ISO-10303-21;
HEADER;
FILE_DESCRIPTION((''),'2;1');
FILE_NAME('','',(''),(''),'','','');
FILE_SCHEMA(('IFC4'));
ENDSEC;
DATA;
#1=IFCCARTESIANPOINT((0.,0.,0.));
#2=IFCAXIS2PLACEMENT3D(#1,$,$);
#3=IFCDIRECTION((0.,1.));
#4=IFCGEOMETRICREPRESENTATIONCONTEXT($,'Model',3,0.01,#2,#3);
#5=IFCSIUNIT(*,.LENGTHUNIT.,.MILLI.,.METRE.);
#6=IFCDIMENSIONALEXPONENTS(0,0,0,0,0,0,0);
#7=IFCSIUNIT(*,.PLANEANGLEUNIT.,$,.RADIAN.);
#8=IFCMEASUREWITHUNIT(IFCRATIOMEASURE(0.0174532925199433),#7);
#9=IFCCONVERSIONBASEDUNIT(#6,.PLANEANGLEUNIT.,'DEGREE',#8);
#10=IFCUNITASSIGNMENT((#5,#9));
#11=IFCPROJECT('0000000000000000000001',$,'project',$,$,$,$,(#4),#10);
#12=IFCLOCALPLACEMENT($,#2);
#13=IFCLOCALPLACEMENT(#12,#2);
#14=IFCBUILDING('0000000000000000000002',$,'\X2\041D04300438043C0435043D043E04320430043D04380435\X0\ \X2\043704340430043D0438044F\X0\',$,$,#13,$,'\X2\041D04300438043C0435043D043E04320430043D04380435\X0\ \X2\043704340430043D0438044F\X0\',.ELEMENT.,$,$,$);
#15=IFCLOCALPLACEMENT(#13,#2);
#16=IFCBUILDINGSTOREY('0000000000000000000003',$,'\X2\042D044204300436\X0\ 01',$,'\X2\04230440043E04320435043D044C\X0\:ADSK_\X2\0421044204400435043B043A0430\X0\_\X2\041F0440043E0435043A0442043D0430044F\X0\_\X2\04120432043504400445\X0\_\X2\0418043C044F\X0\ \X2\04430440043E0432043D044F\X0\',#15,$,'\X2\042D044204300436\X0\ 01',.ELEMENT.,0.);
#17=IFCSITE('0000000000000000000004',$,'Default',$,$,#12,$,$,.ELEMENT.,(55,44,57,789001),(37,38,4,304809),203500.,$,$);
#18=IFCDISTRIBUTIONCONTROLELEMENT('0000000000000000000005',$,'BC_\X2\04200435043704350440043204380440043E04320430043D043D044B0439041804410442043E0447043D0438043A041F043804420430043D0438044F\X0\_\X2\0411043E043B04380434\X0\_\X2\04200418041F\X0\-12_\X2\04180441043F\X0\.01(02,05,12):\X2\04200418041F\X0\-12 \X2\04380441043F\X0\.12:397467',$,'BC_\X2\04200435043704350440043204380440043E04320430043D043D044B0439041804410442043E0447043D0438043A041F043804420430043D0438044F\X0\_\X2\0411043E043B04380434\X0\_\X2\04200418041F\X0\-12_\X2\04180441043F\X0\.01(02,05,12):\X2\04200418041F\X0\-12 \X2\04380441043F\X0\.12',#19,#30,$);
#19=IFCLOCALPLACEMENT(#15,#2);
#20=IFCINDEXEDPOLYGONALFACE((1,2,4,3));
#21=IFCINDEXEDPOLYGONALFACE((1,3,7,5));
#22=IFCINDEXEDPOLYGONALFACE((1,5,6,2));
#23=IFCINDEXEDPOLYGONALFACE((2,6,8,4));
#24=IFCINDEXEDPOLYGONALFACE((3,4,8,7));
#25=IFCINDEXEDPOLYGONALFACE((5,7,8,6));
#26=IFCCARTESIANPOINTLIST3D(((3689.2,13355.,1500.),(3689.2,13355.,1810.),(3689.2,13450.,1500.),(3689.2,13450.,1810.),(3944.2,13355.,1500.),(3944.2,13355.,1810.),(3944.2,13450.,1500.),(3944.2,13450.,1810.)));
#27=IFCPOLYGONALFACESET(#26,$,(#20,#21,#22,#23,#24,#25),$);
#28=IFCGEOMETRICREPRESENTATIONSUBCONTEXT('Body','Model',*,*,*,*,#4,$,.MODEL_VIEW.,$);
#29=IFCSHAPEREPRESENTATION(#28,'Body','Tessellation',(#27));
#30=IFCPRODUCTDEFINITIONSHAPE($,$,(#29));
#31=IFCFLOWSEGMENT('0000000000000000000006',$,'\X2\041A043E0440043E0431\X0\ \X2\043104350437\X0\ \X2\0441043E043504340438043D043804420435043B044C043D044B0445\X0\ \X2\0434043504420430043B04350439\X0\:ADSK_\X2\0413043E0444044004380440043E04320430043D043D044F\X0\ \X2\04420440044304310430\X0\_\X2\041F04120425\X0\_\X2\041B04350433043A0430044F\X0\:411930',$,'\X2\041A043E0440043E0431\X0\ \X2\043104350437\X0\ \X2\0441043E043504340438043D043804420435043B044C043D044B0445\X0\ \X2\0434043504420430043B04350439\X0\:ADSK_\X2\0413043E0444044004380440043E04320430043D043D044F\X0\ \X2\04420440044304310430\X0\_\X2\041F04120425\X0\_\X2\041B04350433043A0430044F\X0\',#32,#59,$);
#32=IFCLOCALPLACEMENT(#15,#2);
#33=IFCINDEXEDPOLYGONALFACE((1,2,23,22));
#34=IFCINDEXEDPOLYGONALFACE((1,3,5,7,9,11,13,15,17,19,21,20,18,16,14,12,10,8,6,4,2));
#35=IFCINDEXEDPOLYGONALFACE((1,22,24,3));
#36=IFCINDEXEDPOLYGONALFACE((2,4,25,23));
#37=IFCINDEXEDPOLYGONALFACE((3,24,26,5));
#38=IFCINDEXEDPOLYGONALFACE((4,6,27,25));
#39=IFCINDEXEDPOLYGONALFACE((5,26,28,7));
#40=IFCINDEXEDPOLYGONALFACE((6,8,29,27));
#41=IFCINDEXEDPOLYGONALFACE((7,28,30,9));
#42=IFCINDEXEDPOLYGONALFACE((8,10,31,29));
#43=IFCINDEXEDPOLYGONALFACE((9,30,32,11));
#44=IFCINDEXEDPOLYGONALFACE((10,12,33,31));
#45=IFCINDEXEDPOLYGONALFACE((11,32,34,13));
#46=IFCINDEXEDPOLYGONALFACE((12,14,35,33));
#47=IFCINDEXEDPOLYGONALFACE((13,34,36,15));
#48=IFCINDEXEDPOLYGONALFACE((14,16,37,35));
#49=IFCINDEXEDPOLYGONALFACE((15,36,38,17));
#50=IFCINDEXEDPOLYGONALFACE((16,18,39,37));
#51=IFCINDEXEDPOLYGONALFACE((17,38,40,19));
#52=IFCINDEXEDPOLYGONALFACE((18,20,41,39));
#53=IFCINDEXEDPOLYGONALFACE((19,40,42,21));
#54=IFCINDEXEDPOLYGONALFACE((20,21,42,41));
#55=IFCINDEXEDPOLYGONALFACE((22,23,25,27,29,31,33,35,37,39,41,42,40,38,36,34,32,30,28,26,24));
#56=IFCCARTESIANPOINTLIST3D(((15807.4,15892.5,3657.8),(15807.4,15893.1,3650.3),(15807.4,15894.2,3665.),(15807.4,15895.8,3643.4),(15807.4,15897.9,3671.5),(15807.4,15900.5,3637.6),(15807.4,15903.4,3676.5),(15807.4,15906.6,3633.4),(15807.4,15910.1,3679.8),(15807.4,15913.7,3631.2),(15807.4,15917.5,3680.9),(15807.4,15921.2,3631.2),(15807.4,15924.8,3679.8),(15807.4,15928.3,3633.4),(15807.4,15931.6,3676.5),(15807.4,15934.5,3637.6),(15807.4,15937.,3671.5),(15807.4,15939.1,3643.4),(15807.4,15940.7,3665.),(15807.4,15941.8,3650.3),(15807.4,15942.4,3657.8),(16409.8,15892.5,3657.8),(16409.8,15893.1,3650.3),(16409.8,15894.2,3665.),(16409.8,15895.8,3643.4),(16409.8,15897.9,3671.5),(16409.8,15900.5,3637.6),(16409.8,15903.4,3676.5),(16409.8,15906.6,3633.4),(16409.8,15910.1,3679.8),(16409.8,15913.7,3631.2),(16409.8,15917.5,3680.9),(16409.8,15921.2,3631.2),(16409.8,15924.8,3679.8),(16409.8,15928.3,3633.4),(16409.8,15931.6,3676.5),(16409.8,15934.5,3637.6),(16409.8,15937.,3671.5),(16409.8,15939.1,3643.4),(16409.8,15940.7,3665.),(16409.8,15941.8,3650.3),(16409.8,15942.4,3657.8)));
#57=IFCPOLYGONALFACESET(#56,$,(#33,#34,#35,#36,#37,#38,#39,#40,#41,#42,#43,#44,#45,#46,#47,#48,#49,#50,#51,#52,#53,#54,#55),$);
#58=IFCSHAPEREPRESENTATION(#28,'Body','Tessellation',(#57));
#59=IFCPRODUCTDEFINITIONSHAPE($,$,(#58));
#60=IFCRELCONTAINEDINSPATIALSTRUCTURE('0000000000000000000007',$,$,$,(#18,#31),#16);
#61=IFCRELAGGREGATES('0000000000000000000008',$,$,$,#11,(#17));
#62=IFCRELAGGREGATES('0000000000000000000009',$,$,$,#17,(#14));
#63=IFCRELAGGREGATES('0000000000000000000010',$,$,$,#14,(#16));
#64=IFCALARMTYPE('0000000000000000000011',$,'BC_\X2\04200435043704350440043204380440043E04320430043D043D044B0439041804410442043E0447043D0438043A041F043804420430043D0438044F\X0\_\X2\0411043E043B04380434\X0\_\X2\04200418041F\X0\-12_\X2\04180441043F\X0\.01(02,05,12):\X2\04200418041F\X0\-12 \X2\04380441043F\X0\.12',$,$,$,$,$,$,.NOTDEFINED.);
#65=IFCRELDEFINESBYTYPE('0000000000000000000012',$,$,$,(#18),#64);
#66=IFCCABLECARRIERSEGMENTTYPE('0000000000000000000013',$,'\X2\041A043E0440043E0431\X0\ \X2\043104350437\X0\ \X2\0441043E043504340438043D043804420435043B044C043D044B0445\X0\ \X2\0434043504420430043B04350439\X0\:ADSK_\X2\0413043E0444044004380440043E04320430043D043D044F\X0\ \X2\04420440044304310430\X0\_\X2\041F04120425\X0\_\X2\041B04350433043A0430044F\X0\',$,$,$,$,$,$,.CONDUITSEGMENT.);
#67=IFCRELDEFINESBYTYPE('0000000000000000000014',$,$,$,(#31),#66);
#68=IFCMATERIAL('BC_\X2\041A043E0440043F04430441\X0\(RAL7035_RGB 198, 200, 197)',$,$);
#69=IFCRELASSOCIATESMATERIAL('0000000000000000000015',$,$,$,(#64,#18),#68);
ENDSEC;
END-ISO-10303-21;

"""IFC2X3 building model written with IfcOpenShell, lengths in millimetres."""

from ifc_helpers import new_model, entity, si_unit, converted_unit, direction, frame, frame_2d, origin, origin_2d_with_axis, place, context, subcontext, project, spatial, rectangle, circle, extrude, source, transform, mapped, material, type_object, type_shapes, element, save


model = new_model("IFC2X3")

# Units and contexts
model_context = context("Model", 3, precision=0.01, world=origin(), true_north=direction((0.0, 1.0)))
body_context = subcontext(model_context, "Body", "Model", "MODEL_VIEW")
ifc_project = project(units=[si_unit("LENGTHUNIT", "METRE", prefix="MILLI"), converted_unit("PLANEANGLEUNIT", "DEGREE", entity("IfcRatioMeasure", 0.0174532925199433), si_unit("PLANEANGLEUNIT", "RADIAN"), dimensions=[0, 0, 0, 0, 0, 0, 0])], contexts=[model_context])

# Site, building, storey
site_placement = place(None, frame((0.0, 0.0, 0.0)))
site = spatial("IfcSite", under=ifc_project, at=site_placement, Name="Default", CompositionType="ELEMENT", RefLatitude=(55, 44, 57, 789001), RefLongitude=(37, 38, 4, 304809), RefElevation=203500.0)
building_placement = place(site_placement, origin())
building = spatial("IfcBuilding", under=site, at=building_placement, Name="Наименование здания", LongName="Наименование здания", CompositionType="ELEMENT")
storey_placement = place(building_placement, origin())
storey = spatial("IfcBuildingStorey", under=building, at=storey_placement, Name="Этаж 01", ObjectType="Уровень:ADSK_Стрелка_Проектная_Вверх_Имя уровня", LongName="Этаж 01", CompositionType="ELEMENT", Elevation=0.0)

# Distribution control element
ifc_material = material(Name="BC_Корпус(RAL7035_RGB 198, 200, 197)")
alarm_type = type_object("IfcAlarmType", Name="BC_РезервированныйИсточникПитания_Болид_РИП-12_Исп.01(02,05,12):РИП-12 исп.12", PredefinedType="NOTDEFINED", material=ifc_material)
shared_shape = source(origin(), body_context, "Body", "SweptSolid", [
    extrude(rectangle(XDim=255.0, YDim=310.0, at=origin_2d_with_axis()), frame((0.0, 0.0, 0.0), z_axis=(0.0, 0.0, 1.0), x_axis=(-1.0, 0.0, 0.0)), (0.0, 0.0, 1.0), 95.0),
])
type_shapes(alarm_type, [shared_shape])
distribution_control_element_placement = place(storey_placement, frame((3816.7, 13450.0, 1655.0), z_axis=(0.0, -1.0, 0.0), x_axis=(1.0, 0.0, 0.0)))
element("IfcDistributionControlElement", 1, at=distribution_control_element_placement, inside=storey, type_object=alarm_type, material=ifc_material, Name="BC_РезервированныйИсточникПитания_Болид_РИП-12_Исп.01(02,05,12):РИП-12 исп.12:397467", ObjectType="BC_РезервированныйИсточникПитания_Болид_РИП-12_Исп.01(02,05,12):РИП-12 исп.12", context=body_context, shape_type="MappedRepresentation", body=[
    mapped(shared_shape, transform((0.0, 0.0, 0.0), scale=1.0)),
])

# Flow segment
cable_carrier_segment_type = type_object("IfcCableCarrierSegmentType", Name="Короб без соединительных деталей:ADSK_Гофрировання труба_ПВХ_Легкая", PredefinedType="CONDUITSEGMENT")
flow_segment_1_placement = place(storey_placement, frame((15807.4, 15890.9, 3629.3)))
element("IfcFlowSegment", 2, at=flow_segment_1_placement, inside=storey, type_object=cable_carrier_segment_type, Name="Короб без соединительных деталей:ADSK_Гофрировання труба_ПВХ_Легкая:411930", ObjectType="Короб без соединительных деталей:ADSK_Гофрировання труба_ПВХ_Легкая", context=body_context, shape_type="SweptSolid", body=[
    extrude(circle(Radius=25.0, at=frame_2d((0.0, 0.0), x_axis=(1.0, 0.0))), frame((0.0, 26.6, 26.6), z_axis=(1.0, 0.0, -0.000002), x_axis=(0.000002, 0.0, 1.0)), (0.0, 0.0, 1.0), 602.4),
])

save(model, "model.ifc")
